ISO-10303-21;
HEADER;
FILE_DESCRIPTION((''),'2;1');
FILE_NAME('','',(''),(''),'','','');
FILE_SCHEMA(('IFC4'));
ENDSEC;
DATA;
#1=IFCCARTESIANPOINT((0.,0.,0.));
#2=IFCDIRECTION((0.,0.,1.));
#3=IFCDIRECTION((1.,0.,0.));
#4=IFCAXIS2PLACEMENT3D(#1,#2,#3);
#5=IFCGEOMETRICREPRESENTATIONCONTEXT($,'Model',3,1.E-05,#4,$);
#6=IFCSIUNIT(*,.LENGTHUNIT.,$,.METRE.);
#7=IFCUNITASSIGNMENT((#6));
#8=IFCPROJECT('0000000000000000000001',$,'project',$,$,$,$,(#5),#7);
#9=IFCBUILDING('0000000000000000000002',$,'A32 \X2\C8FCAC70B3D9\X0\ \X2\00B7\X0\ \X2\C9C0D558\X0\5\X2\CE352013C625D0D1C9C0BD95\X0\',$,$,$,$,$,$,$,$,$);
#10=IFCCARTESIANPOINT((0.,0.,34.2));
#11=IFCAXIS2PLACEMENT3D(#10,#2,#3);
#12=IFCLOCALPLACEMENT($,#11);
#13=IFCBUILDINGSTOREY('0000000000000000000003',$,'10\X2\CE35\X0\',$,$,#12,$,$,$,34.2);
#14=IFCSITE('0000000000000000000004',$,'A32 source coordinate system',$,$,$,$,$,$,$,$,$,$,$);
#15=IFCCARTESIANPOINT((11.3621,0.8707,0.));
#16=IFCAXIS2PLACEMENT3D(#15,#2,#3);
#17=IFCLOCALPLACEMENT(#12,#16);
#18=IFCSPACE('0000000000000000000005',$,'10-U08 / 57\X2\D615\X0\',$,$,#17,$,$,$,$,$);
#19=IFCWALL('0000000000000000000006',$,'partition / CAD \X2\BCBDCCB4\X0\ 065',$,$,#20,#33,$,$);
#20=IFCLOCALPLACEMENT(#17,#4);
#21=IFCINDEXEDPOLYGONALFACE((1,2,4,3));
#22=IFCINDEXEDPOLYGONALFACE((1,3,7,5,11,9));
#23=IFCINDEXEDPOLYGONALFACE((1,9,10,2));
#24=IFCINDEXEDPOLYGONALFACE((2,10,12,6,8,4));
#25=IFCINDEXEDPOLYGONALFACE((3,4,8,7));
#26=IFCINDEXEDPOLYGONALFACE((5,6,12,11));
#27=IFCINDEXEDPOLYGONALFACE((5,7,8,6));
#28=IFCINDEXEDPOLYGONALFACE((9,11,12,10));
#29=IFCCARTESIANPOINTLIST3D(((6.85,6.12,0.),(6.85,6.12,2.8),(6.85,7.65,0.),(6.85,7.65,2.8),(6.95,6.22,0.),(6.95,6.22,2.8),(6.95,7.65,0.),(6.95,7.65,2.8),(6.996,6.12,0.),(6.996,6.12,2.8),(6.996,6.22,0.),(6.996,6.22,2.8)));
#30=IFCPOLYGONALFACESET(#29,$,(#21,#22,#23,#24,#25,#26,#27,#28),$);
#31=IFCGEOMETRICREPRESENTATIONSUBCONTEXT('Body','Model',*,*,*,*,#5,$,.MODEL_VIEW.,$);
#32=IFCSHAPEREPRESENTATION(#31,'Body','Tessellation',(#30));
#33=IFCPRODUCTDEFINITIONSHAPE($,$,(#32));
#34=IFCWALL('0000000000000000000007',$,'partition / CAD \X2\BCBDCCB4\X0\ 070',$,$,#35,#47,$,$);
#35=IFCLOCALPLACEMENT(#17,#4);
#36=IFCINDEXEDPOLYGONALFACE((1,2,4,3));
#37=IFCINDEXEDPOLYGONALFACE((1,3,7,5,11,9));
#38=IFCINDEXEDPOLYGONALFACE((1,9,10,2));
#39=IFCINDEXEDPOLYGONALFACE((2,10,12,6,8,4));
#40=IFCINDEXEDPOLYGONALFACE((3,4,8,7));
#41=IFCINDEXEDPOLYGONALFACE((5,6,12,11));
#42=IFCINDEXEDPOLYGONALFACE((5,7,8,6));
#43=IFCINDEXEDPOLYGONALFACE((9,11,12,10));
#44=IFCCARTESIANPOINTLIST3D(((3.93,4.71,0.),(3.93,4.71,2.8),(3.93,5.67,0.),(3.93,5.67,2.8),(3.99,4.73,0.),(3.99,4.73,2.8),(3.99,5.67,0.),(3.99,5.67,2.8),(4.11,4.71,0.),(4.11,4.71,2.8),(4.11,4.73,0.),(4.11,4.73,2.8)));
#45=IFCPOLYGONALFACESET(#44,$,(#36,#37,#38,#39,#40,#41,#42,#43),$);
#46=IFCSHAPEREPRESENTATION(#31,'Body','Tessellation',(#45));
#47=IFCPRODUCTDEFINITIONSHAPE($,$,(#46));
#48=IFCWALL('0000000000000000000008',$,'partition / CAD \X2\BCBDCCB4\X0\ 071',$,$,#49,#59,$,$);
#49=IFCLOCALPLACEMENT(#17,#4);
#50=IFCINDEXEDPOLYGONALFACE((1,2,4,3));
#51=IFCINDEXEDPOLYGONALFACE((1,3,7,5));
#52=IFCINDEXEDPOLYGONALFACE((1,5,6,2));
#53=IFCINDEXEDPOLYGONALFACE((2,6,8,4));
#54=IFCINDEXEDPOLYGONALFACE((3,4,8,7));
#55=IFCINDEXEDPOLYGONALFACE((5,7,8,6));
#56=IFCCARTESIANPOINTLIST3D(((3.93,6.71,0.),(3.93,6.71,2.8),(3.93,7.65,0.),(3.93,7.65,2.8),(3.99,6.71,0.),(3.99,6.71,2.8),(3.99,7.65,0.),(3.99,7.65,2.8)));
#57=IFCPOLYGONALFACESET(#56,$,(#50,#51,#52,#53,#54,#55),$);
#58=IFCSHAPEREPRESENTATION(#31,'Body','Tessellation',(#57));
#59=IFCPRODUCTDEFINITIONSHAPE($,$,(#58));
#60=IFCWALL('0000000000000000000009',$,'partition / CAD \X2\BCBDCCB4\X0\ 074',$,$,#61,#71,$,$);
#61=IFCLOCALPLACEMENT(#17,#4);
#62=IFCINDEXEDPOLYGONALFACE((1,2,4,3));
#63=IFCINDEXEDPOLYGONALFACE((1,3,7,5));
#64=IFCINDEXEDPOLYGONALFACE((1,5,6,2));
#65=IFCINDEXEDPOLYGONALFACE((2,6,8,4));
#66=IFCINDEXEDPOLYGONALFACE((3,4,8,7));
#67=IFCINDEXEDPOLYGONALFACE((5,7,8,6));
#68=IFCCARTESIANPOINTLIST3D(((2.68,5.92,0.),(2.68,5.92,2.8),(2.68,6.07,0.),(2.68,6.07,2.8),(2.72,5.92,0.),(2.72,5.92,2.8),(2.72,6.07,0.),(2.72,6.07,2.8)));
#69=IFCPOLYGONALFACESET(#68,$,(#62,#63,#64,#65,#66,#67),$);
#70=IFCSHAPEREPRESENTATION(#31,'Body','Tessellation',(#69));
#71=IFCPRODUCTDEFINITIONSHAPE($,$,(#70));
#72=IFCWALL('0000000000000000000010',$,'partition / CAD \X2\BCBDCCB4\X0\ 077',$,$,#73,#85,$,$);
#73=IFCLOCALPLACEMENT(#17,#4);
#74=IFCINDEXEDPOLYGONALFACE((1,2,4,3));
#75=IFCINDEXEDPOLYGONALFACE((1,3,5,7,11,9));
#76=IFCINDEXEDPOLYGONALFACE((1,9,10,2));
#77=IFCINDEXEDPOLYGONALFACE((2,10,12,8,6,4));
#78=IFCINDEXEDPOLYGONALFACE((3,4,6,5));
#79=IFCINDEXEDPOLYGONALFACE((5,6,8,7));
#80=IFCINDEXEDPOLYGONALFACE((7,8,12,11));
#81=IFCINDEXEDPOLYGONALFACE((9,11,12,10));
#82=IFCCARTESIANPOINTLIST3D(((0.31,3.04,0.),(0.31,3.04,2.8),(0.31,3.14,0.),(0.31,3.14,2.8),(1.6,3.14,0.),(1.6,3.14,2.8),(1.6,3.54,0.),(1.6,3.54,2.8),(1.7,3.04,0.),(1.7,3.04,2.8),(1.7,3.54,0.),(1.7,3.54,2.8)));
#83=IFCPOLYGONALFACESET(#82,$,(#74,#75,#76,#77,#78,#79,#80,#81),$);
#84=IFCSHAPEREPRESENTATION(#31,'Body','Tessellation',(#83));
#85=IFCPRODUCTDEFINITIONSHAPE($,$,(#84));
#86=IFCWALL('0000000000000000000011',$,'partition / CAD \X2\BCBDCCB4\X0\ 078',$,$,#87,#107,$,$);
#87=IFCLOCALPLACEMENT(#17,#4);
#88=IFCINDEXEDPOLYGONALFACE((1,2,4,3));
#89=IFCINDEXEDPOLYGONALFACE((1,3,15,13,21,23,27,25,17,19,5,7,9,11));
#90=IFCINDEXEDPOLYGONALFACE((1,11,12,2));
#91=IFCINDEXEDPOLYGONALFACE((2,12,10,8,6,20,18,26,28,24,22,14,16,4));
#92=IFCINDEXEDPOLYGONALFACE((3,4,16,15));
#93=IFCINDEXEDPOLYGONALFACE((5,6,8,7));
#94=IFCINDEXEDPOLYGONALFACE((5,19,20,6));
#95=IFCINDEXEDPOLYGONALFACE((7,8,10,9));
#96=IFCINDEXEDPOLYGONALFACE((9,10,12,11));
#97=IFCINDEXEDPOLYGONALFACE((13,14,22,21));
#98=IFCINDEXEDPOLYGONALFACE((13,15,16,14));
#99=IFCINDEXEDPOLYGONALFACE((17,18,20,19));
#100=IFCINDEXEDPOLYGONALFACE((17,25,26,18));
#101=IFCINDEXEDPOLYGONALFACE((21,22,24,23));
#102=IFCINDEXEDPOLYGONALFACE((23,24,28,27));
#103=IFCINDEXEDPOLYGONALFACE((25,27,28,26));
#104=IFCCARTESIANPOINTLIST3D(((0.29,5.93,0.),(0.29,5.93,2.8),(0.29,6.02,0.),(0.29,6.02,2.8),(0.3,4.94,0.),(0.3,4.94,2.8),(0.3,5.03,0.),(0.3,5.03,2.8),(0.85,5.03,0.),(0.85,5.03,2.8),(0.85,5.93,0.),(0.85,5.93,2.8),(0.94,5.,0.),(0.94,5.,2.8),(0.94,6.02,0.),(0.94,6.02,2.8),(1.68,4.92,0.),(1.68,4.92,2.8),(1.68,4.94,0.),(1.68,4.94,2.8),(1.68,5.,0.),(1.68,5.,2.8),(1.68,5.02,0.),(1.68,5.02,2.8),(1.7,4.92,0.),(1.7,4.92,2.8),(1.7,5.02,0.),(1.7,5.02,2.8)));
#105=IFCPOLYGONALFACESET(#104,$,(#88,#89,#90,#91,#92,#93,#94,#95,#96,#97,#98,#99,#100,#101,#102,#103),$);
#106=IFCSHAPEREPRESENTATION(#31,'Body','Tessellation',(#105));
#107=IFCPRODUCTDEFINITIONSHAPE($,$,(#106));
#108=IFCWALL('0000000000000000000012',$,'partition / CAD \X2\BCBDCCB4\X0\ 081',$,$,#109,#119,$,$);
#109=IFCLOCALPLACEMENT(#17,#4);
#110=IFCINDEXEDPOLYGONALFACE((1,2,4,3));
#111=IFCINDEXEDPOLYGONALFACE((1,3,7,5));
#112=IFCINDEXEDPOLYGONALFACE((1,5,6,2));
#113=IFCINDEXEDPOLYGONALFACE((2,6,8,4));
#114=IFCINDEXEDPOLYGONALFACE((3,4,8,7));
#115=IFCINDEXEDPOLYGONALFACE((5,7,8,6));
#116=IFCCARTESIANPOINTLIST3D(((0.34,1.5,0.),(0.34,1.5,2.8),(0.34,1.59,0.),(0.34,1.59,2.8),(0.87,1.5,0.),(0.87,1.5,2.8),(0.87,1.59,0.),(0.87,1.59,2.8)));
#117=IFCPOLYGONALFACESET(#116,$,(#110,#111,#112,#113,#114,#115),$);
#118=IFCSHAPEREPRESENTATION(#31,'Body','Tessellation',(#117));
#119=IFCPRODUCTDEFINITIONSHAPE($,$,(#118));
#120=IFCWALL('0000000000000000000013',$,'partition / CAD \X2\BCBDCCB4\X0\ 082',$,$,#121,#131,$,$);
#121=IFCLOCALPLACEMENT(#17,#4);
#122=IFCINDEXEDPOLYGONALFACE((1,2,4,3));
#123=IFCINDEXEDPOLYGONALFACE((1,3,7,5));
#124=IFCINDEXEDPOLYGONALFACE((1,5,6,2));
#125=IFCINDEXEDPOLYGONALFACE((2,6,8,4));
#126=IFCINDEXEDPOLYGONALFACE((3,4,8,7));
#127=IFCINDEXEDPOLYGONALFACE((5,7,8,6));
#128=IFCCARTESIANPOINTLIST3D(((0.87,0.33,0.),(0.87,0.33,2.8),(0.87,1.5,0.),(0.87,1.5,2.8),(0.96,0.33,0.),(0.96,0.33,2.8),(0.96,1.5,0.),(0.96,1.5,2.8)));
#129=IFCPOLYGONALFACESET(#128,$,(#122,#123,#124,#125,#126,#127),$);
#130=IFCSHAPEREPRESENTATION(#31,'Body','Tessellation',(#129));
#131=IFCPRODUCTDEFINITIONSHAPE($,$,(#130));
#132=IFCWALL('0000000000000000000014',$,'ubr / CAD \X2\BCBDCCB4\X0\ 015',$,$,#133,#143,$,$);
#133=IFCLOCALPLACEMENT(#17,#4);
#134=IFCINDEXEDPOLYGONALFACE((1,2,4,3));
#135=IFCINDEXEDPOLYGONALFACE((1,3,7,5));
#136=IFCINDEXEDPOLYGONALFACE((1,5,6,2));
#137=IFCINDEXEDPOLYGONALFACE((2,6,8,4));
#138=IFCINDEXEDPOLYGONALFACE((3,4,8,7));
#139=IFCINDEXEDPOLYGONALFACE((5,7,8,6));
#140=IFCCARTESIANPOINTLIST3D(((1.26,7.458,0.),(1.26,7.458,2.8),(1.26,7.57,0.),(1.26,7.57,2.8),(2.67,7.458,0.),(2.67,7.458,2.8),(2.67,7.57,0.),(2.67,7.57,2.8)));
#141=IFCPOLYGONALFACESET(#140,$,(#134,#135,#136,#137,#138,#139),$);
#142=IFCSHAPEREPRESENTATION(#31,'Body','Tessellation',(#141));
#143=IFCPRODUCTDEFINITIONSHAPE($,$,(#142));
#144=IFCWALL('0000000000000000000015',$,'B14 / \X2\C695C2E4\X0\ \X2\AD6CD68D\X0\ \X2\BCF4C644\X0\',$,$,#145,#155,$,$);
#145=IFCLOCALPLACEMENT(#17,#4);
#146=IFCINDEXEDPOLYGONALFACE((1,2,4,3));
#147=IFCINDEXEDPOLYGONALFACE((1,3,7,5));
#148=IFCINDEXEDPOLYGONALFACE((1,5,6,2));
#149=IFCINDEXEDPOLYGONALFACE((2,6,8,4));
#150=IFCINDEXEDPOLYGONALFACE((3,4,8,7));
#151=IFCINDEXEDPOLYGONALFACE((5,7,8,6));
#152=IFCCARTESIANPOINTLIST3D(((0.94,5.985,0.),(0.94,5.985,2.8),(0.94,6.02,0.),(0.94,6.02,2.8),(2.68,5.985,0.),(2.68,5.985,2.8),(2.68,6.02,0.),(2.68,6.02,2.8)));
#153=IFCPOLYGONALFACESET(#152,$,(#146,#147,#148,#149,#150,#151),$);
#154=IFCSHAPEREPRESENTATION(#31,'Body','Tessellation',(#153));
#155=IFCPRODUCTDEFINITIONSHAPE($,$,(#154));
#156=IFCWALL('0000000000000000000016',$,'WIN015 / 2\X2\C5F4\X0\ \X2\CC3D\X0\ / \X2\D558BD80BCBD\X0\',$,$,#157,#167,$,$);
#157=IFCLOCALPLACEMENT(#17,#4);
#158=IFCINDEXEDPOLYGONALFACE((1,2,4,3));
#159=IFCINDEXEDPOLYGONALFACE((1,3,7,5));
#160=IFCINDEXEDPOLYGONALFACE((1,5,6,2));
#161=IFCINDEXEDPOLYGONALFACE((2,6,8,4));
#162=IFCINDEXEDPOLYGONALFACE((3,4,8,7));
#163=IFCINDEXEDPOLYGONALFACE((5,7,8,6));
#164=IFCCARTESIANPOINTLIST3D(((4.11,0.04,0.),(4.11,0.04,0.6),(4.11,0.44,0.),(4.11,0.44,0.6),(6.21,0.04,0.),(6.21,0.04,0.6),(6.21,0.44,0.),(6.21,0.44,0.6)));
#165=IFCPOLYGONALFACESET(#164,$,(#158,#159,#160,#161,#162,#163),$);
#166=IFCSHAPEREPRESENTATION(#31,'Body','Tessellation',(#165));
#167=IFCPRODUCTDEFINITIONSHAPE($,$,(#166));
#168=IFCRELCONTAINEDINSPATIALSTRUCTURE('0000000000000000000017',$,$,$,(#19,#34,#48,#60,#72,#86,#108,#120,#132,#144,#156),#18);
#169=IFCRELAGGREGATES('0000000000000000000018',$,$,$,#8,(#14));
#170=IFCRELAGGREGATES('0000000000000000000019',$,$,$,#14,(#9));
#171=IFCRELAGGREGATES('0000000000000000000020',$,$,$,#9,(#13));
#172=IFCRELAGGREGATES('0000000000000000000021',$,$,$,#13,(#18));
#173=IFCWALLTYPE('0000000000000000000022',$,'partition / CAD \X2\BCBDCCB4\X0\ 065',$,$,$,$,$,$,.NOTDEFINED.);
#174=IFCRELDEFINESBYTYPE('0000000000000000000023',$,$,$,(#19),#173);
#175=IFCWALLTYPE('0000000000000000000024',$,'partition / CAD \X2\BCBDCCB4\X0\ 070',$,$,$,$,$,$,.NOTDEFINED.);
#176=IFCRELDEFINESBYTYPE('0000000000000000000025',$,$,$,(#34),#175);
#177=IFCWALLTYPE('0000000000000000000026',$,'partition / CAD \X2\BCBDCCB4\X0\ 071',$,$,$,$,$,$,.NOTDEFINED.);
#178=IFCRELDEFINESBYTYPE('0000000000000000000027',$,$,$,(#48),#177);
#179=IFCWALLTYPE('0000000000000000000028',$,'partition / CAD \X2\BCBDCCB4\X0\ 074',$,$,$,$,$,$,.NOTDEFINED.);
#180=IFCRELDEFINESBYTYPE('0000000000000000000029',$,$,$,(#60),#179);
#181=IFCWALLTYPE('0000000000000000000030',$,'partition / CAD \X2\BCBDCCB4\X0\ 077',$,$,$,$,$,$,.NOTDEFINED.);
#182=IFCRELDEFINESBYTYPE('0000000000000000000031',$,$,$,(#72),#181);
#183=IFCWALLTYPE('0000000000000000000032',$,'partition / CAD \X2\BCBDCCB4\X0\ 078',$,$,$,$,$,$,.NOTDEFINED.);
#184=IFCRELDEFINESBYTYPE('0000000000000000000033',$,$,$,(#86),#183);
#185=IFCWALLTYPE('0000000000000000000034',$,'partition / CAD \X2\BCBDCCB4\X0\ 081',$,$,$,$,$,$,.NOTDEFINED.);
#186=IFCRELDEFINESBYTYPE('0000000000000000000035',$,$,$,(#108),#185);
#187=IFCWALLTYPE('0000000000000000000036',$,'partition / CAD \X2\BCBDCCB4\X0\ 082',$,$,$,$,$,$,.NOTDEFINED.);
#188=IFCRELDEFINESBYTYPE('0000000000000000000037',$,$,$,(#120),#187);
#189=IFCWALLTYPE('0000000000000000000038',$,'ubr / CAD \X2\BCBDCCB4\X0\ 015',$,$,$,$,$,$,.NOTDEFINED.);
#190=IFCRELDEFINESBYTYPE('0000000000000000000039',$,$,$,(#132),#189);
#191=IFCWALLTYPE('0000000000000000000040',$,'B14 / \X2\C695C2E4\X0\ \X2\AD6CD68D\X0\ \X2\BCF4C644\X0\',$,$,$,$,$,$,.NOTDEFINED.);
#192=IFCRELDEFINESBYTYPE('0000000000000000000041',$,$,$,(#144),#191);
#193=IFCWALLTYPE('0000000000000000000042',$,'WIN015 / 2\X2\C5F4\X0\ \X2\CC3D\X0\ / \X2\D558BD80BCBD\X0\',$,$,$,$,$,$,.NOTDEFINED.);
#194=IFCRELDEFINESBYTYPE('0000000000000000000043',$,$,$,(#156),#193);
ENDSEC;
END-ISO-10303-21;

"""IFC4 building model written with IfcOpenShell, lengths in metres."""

from ifc_helpers import new_model, si_unit, frame, origin, origin_with_axes, place, context, subcontext, project, spatial, polyline, outline, extrude, source, transform, mapped, type_object, type_shapes, element, save


model = new_model("IFC4")

# Units and contexts
model_context = context("Model", 3, precision=1e-05, world=origin_with_axes())
body_context = subcontext(model_context, "Body", "Model", "MODEL_VIEW")
ifc_project = project(units=[si_unit("LENGTHUNIT", "METRE")], contexts=[model_context])

# Site, building, storey, space
storey_placement = place(None, frame((0.0, 0.0, 34.2), z_axis=(0.0, 0.0, 1.0), x_axis=(1.0, 0.0, 0.0)))
space_placement = place(storey_placement, frame((11.3621, 0.8707, 0.0), z_axis=(0.0, 0.0, 1.0), x_axis=(1.0, 0.0, 0.0)))
site = spatial("IfcSite", under=ifc_project, Name="A32 source coordinate system")
building = spatial("IfcBuilding", under=site, Name="A32 주거동 · 지하5층–옥탑지붕")
storey = spatial("IfcBuildingStorey", under=building, at=storey_placement, Name="10층", Elevation=34.2)
space = spatial("IfcSpace", under=storey, at=space_placement, Name="10-U08 / 57형")

# Walls
wall_type_1 = type_object("IfcWallType", Name="partition / CAD 벽체 065", PredefinedType="NOTDEFINED")
shared_shape_1 = source(origin(), body_context, "Body", "SweptSolid", [
    extrude(outline(polyline([(6.95, 7.65), (6.95, 6.22), (6.996, 6.22), (6.996, 6.12), (6.85, 6.12), (6.85, 7.65), (6.95, 7.65)])), origin(), (0.0, 0.0, 1.0), 2.8),
])
type_shapes(wall_type_1, [shared_shape_1])
wall_1_placement = place(space_placement, origin_with_axes())
element("IfcWall", 1, at=wall_1_placement, inside=space, type_object=wall_type_1, Name="partition / CAD 벽체 065", context=body_context, shape_type="MappedRepresentation", body=[
    mapped(shared_shape_1, transform((0.0, 0.0, 0.0), scale=1.0)),
])
wall_type_2 = type_object("IfcWallType", Name="partition / CAD 벽체 070", PredefinedType="NOTDEFINED")
shared_shape_2 = source(origin(), body_context, "Body", "SweptSolid", [
    extrude(outline(polyline([(4.11, 4.73), (4.11, 4.71), (3.93, 4.71), (3.93, 5.67), (3.99, 5.67), (3.99, 4.73), (4.11, 4.73)])), origin(), (0.0, 0.0, 1.0), 2.8),
])
type_shapes(wall_type_2, [shared_shape_2])
wall_2_placement = place(space_placement, origin_with_axes())
element("IfcWall", 2, at=wall_2_placement, inside=space, type_object=wall_type_2, Name="partition / CAD 벽체 070", context=body_context, shape_type="MappedRepresentation", body=[
    mapped(shared_shape_2, transform((0.0, 0.0, 0.0), scale=1.0)),
])
wall_type_3 = type_object("IfcWallType", Name="partition / CAD 벽체 071", PredefinedType="NOTDEFINED")
shared_shape_3 = source(origin(), body_context, "Body", "SweptSolid", [
    extrude(outline(polyline([(3.93, 6.71), (3.93, 7.65), (3.99, 7.65), (3.99, 6.71), (3.93, 6.71)])), origin(), (0.0, 0.0, 1.0), 2.8),
])
type_shapes(wall_type_3, [shared_shape_3])
wall_3_placement = place(space_placement, origin_with_axes())
element("IfcWall", 3, at=wall_3_placement, inside=space, type_object=wall_type_3, Name="partition / CAD 벽체 071", context=body_context, shape_type="MappedRepresentation", body=[
    mapped(shared_shape_3, transform((0.0, 0.0, 0.0), scale=1.0)),
])
wall_type_4 = type_object("IfcWallType", Name="partition / CAD 벽체 074", PredefinedType="NOTDEFINED")
shared_shape_4 = source(origin(), body_context, "Body", "SweptSolid", [
    extrude(outline(polyline([(2.72, 6.07), (2.72, 5.92), (2.68, 5.92), (2.68, 6.07), (2.72, 6.07)])), origin(), (0.0, 0.0, 1.0), 2.8),
])
type_shapes(wall_type_4, [shared_shape_4])
wall_4_placement = place(space_placement, origin_with_axes())
element("IfcWall", 4, at=wall_4_placement, inside=space, type_object=wall_type_4, Name="partition / CAD 벽체 074", context=body_context, shape_type="MappedRepresentation", body=[
    mapped(shared_shape_4, transform((0.0, 0.0, 0.0), scale=1.0)),
])
wall_type_5 = type_object("IfcWallType", Name="partition / CAD 벽체 077", PredefinedType="NOTDEFINED")
shared_shape_5 = source(origin(), body_context, "Body", "SweptSolid", [
    extrude(outline(polyline([(1.7, 3.54), (1.7, 3.04), (0.31, 3.04), (0.31, 3.14), (1.6, 3.14), (1.6, 3.54), (1.7, 3.54)])), origin(), (0.0, 0.0, 1.0), 2.8),
])
type_shapes(wall_type_5, [shared_shape_5])
wall_5_placement = place(space_placement, origin_with_axes())
element("IfcWall", 5, at=wall_5_placement, inside=space, type_object=wall_type_5, Name="partition / CAD 벽체 077", context=body_context, shape_type="MappedRepresentation", body=[
    mapped(shared_shape_5, transform((0.0, 0.0, 0.0), scale=1.0)),
])
wall_type_6 = type_object("IfcWallType", Name="partition / CAD 벽체 078", PredefinedType="NOTDEFINED")
shared_shape_6 = source(origin(), body_context, "Body", "SweptSolid", [
    extrude(outline(polyline([(1.7, 4.92), (1.68, 4.92), (1.68, 4.94), (0.3, 4.94), (0.3, 5.03), (0.85, 5.03), (0.85, 5.93), (0.29, 5.93), (0.29, 6.02), (0.94, 6.02), (0.94, 5.0), (1.68, 5.0), (1.68, 5.02), (1.7, 5.02), (1.7, 4.92)])), origin(), (0.0, 0.0, 1.0), 2.8),
])
type_shapes(wall_type_6, [shared_shape_6])
wall_6_placement = place(space_placement, origin_with_axes())
element("IfcWall", 6, at=wall_6_placement, inside=space, type_object=wall_type_6, Name="partition / CAD 벽체 078", context=body_context, shape_type="MappedRepresentation", body=[
    mapped(shared_shape_6, transform((0.0, 0.0, 0.0), scale=1.0)),
])
wall_type_7 = type_object("IfcWallType", Name="partition / CAD 벽체 081", PredefinedType="NOTDEFINED")
shared_shape_7 = source(origin(), body_context, "Body", "SweptSolid", [
    extrude(outline(polyline([(0.34, 1.59), (0.87, 1.59), (0.87, 1.5), (0.34, 1.5), (0.34, 1.59)])), origin(), (0.0, 0.0, 1.0), 2.8),
])
type_shapes(wall_type_7, [shared_shape_7])
wall_7_placement = place(space_placement, origin_with_axes())
element("IfcWall", 7, at=wall_7_placement, inside=space, type_object=wall_type_7, Name="partition / CAD 벽체 081", context=body_context, shape_type="MappedRepresentation", body=[
    mapped(shared_shape_7, transform((0.0, 0.0, 0.0), scale=1.0)),
])
wall_type_8 = type_object("IfcWallType", Name="partition / CAD 벽체 082", PredefinedType="NOTDEFINED")
shared_shape_8 = source(origin(), body_context, "Body", "SweptSolid", [
    extrude(outline(polyline([(0.96, 0.33), (0.87, 0.33), (0.87, 1.5), (0.96, 1.5), (0.96, 0.33)])), origin(), (0.0, 0.0, 1.0), 2.8),
])
type_shapes(wall_type_8, [shared_shape_8])
wall_8_placement = place(space_placement, origin_with_axes())
element("IfcWall", 8, at=wall_8_placement, inside=space, type_object=wall_type_8, Name="partition / CAD 벽체 082", context=body_context, shape_type="MappedRepresentation", body=[
    mapped(shared_shape_8, transform((0.0, 0.0, 0.0), scale=1.0)),
])
wall_type_9 = type_object("IfcWallType", Name="ubr / CAD 벽체 015", PredefinedType="NOTDEFINED")
shared_shape_9 = source(origin(), body_context, "Body", "SweptSolid", [
    extrude(outline(polyline([(2.67, 7.57), (2.67, 7.458), (1.26, 7.458), (1.26, 7.57), (2.67, 7.57)])), origin(), (0.0, 0.0, 1.0), 2.8),
])
type_shapes(wall_type_9, [shared_shape_9])
wall_9_placement = place(space_placement, origin_with_axes())
element("IfcWall", 9, at=wall_9_placement, inside=space, type_object=wall_type_9, Name="ubr / CAD 벽체 015", context=body_context, shape_type="MappedRepresentation", body=[
    mapped(shared_shape_9, transform((0.0, 0.0, 0.0), scale=1.0)),
])
wall_type_10 = type_object("IfcWallType", Name="B14 / 욕실 구획 보완", PredefinedType="NOTDEFINED")
shared_shape_10 = source(origin(), body_context, "Body", "SweptSolid", [
    extrude(outline(polyline([(2.68, 5.985), (0.94, 5.985), (0.94, 6.02), (2.68, 6.02), (2.68, 5.985)])), origin(), (0.0, 0.0, 1.0), 2.8),
])
type_shapes(wall_type_10, [shared_shape_10])
wall_10_placement = place(space_placement, origin_with_axes())
element("IfcWall", 10, at=wall_10_placement, inside=space, type_object=wall_type_10, Name="B14 / 욕실 구획 보완", context=body_context, shape_type="MappedRepresentation", body=[
    mapped(shared_shape_10, transform((0.0, 0.0, 0.0), scale=1.0)),
])
wall_type_11 = type_object("IfcWallType", Name="WIN015 / 2열 창 / 하부벽", PredefinedType="NOTDEFINED")
shared_shape_11 = source(origin(), body_context, "Body", "SweptSolid", [
    extrude(outline(polyline([(4.11, 0.04), (4.11, 0.44), (6.21, 0.44), (6.21, 0.04), (4.11, 0.04)])), origin(), (0.0, 0.0, 1.0), 0.6),
])
type_shapes(wall_type_11, [shared_shape_11])
wall_11_placement = place(space_placement, origin_with_axes())
element("IfcWall", 11, at=wall_11_placement, inside=space, type_object=wall_type_11, Name="WIN015 / 2열 창 / 하부벽", context=body_context, shape_type="MappedRepresentation", body=[
    mapped(shared_shape_11, transform((0.0, 0.0, 0.0), scale=1.0)),
])

save(model, "model.ifc")
